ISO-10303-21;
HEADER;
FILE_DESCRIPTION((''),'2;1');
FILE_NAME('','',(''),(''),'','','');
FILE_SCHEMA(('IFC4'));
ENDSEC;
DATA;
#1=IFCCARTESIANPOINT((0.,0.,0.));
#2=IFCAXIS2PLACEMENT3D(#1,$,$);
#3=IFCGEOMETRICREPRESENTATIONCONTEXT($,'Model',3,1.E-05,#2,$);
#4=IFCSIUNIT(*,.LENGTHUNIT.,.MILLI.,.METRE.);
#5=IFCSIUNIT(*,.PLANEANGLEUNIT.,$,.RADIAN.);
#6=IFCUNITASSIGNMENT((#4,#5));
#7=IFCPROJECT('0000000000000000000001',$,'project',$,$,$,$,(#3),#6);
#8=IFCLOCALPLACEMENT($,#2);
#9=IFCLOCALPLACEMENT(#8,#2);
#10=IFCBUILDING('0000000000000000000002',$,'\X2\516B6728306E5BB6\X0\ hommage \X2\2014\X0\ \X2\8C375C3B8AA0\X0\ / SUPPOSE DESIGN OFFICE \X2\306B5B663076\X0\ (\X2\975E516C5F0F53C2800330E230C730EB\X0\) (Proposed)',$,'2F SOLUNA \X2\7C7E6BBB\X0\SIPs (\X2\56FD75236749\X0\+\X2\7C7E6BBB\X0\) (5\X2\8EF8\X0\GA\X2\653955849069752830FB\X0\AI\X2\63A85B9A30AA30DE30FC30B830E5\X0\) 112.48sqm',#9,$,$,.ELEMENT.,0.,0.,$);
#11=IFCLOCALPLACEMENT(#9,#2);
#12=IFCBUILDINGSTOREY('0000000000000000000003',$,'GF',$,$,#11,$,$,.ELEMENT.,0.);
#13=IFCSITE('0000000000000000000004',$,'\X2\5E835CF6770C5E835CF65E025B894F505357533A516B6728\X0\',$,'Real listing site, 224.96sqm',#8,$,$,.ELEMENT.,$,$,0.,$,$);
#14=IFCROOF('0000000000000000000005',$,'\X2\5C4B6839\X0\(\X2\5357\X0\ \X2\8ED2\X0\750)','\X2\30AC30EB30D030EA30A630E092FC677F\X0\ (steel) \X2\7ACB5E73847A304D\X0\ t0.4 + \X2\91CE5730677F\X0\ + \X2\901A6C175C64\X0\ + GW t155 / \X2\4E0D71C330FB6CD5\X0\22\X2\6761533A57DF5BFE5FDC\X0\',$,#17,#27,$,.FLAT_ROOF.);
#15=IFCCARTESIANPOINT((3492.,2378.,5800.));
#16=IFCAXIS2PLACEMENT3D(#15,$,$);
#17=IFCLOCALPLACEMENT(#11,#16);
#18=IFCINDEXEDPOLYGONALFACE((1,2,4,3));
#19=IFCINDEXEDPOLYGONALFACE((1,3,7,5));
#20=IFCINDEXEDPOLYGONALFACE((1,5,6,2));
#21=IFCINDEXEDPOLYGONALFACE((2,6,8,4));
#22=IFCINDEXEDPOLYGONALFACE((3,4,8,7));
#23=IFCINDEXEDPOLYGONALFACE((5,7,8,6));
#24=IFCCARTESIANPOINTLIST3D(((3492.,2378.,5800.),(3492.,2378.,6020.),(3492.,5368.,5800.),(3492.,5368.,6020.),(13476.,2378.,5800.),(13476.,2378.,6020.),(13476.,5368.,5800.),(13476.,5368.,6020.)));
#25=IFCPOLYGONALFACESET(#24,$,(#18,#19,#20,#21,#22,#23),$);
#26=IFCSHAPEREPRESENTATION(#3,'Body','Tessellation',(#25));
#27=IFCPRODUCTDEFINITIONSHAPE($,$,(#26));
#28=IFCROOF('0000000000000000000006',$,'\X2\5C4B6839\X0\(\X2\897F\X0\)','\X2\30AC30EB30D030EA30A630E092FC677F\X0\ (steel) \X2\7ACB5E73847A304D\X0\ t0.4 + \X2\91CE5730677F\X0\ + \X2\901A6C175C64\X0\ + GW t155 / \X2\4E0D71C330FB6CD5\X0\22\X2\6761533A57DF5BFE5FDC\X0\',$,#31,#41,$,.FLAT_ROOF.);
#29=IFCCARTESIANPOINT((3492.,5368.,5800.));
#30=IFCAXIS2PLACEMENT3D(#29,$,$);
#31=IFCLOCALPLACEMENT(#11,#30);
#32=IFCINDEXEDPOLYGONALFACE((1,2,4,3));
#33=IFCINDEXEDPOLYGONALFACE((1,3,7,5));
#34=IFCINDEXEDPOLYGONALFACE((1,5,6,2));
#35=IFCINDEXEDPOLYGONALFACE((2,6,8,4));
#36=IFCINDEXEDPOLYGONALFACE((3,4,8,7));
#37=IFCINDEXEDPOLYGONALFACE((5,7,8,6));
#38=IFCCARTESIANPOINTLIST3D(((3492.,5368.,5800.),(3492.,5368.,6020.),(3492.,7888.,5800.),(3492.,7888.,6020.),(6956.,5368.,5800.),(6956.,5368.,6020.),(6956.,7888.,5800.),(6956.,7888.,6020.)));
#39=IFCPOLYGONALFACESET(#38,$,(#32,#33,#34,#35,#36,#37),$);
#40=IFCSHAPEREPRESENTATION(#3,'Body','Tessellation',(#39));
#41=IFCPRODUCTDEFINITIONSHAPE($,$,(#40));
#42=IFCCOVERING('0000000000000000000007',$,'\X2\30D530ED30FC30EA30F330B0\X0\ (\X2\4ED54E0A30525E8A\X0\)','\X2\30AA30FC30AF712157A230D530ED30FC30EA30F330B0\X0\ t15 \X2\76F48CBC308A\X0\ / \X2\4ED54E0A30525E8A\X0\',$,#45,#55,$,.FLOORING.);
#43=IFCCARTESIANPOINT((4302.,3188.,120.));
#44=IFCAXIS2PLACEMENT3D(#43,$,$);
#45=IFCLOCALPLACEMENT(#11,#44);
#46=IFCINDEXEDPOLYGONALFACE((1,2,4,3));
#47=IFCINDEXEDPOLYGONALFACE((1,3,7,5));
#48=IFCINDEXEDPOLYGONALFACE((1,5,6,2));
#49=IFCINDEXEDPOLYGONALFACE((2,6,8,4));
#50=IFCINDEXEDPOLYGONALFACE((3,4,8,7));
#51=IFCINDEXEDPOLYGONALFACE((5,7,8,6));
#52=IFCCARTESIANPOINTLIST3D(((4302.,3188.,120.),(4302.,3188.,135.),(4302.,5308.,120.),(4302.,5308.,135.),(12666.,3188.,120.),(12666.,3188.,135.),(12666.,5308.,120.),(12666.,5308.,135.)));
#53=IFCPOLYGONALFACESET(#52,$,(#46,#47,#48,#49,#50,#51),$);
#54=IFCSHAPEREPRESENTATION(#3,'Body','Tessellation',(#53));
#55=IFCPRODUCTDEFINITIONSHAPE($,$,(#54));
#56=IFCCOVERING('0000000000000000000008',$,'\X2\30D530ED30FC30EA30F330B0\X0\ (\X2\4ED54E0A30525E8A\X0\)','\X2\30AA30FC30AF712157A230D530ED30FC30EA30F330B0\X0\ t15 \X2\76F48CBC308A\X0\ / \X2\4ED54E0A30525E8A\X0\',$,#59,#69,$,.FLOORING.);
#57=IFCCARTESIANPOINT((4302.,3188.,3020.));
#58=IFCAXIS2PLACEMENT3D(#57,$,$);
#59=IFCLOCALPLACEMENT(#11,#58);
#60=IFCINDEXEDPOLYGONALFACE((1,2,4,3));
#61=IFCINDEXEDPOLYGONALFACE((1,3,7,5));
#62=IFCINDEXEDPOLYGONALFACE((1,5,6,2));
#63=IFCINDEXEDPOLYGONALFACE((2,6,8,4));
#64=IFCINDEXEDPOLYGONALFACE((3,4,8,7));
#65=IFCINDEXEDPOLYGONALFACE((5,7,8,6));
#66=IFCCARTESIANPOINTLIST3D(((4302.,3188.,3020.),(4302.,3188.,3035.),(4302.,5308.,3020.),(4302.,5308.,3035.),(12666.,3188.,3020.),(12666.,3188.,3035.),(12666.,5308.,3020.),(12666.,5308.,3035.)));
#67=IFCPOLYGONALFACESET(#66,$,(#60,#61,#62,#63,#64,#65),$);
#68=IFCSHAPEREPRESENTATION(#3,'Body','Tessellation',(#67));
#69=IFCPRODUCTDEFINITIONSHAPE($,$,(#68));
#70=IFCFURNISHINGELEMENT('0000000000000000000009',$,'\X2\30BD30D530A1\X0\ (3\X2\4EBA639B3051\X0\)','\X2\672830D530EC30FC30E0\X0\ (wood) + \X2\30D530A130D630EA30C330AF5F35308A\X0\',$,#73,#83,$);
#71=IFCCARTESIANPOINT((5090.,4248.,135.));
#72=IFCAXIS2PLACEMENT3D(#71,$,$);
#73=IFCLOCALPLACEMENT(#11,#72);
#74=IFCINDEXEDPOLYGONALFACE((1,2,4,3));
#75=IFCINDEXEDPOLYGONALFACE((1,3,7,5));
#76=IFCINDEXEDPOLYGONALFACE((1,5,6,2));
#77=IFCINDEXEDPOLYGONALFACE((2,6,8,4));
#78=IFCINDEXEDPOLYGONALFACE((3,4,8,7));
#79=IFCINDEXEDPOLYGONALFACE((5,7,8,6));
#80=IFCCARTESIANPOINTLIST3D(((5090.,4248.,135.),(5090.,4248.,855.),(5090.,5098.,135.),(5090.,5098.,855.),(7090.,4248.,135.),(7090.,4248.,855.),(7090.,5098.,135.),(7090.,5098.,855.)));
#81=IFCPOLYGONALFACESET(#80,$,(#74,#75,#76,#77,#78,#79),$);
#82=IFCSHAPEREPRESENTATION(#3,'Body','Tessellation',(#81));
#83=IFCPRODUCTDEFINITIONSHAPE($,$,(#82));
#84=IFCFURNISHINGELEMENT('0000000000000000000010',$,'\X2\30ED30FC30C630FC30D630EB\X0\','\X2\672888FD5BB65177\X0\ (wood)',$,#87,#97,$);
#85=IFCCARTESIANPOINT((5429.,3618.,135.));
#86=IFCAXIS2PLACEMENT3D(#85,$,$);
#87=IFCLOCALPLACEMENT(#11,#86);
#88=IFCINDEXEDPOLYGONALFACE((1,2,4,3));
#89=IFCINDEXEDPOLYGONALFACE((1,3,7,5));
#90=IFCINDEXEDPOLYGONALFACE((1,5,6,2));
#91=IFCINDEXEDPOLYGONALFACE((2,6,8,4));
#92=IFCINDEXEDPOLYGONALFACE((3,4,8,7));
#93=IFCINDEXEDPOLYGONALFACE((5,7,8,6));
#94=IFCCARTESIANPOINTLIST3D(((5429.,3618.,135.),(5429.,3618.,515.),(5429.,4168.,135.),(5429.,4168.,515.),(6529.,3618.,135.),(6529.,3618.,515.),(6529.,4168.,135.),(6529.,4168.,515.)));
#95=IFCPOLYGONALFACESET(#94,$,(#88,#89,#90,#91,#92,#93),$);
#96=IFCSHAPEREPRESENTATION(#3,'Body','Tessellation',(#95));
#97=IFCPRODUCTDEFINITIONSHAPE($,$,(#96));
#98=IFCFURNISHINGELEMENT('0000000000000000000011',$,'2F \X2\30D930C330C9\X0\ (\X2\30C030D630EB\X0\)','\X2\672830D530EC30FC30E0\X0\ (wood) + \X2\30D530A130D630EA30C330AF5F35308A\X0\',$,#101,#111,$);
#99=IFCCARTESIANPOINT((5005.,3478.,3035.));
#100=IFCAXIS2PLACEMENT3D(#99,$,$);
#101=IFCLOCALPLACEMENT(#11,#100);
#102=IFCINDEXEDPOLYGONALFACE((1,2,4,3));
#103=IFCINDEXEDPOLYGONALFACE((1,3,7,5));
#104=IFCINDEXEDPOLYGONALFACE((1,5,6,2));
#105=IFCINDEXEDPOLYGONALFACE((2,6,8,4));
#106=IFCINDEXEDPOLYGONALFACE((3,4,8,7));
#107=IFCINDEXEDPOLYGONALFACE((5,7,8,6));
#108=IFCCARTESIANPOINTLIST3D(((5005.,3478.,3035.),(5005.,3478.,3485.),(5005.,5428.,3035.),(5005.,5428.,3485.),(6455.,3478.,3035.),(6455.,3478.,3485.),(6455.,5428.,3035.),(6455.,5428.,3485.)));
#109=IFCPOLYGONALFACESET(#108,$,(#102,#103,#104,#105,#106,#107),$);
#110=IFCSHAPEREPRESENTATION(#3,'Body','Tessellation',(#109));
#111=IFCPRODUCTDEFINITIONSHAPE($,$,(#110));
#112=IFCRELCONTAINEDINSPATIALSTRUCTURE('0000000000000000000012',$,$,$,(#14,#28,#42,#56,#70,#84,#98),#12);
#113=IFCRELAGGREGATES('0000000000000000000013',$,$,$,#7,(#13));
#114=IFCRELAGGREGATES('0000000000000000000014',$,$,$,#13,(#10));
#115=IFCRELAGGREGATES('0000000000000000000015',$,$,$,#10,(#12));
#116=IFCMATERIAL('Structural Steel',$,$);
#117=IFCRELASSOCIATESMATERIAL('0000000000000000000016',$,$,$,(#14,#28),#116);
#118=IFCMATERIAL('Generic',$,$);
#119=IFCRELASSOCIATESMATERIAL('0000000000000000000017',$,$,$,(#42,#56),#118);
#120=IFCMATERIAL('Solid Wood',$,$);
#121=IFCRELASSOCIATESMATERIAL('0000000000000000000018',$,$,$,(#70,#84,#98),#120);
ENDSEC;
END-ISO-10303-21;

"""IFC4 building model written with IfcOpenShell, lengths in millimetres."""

from ifc_helpers import new_model, si_unit, frame, frame_2d, origin, place, context, project, spatial, rectangle, extrude, material, element, save


model = new_model("IFC4")

# Units and contexts
model_context = context("Model", 3, precision=1e-05, world=origin())
ifc_project = project(units=[si_unit("LENGTHUNIT", "METRE", prefix="MILLI"), si_unit("PLANEANGLEUNIT", "RADIAN")], contexts=[model_context])

# Site, building, storey
site_placement = place(None, origin())
site = spatial("IfcSite", under=ifc_project, at=site_placement, Name="広島県広島市安佐南区八木", ObjectType="Real listing site, 224.96sqm", CompositionType="ELEMENT", RefElevation=0.0)
building_placement = place(site_placement, origin())
building = spatial("IfcBuilding", under=site, at=building_placement, Name="八木の家 hommage — 谷尻誠 / SUPPOSE DESIGN OFFICE に学ぶ (非公式参考モデル) (Proposed)", ObjectType="2F SOLUNA 籾殻SIPs (国産杉+籾殻) (5軸GA改善適用・AI推定オマージュ) 112.48sqm", CompositionType="ELEMENT", ElevationOfRefHeight=0.0, ElevationOfTerrain=0.0)
storey_placement = place(building_placement, origin())
storey = spatial("IfcBuildingStorey", under=building, at=storey_placement, Name="GF", CompositionType="ELEMENT", Elevation=0.0)

# Shared definitions
ifc_material_1 = material(Name="Solid Wood")

# Roofs
ifc_material_2 = material(Name="Structural Steel")
roof_1_placement = place(storey_placement, frame((3492.0, 2378.0, 5800.0)))
element("IfcRoof", 1, at=roof_1_placement, inside=storey, material=ifc_material_2, Name="屋根(南 軒750)", Description="ガルバリウム鋼板 (steel) 立平葺き t0.4 + 野地板 + 通気層 + GW t155 / 不燃・法22条区域対応", PredefinedType="FLAT_ROOF", context=model_context, shape_type="SweptSolid", body=[
    extrude(rectangle(XDim=9984.0, YDim=2990.0, at=frame_2d((4992.0, 1495.0))), frame((3492.0, 2378.0, 5800.0)), (0.0, 0.0, 1.0), 220.0),
])
roof_2_placement = place(storey_placement, frame((3492.0, 5368.0, 5800.0)))
element("IfcRoof", 2, at=roof_2_placement, inside=storey, material=ifc_material_2, Name="屋根(西)", Description="ガルバリウム鋼板 (steel) 立平葺き t0.4 + 野地板 + 通気層 + GW t155 / 不燃・法22条区域対応", PredefinedType="FLAT_ROOF", context=model_context, shape_type="SweptSolid", body=[
    extrude(rectangle(XDim=3464.0, YDim=2520.0, at=frame_2d((1732.0, 1260.0))), frame((3492.0, 5368.0, 5800.0)), (0.0, 0.0, 1.0), 220.0),
])

# Coverings
ifc_material_3 = material(Name="Generic")
covering_1_placement = place(storey_placement, frame((4302.0, 3188.0, 120.0)))
element("IfcCovering", 3, at=covering_1_placement, inside=storey, material=ifc_material_3, Name="フローリング (仕上げ床)", Description="オーク無垢フローリング t15 直貼り / 仕上げ床", PredefinedType="FLOORING", context=model_context, shape_type="SweptSolid", body=[
    extrude(rectangle(XDim=8364.0, YDim=2120.0, at=frame_2d((4182.0, 1060.0))), frame((4302.0, 3188.0, 120.0)), (0.0, 0.0, 1.0), 15.0),
])
covering_2_placement = place(storey_placement, frame((4302.0, 3188.0, 3020.0)))
element("IfcCovering", 4, at=covering_2_placement, inside=storey, material=ifc_material_3, Name="フローリング (仕上げ床)", Description="オーク無垢フローリング t15 直貼り / 仕上げ床", PredefinedType="FLOORING", context=model_context, shape_type="SweptSolid", body=[
    extrude(rectangle(XDim=8364.0, YDim=2120.0, at=frame_2d((4182.0, 1060.0))), frame((4302.0, 3188.0, 3020.0)), (0.0, 0.0, 1.0), 15.0),
])

# Furnishing elements
furnishing_1_placement = place(storey_placement, frame((5090.0, 4248.0, 135.0)))
element("IfcFurnishingElement", 5, at=furnishing_1_placement, inside=storey, material=ifc_material_1, Name="ソファ (3人掛け)", Description="木フレーム (wood) + ファブリック張り", context=model_context, shape_type="SweptSolid", body=[
    extrude(rectangle(XDim=2000.0, YDim=850.0, at=frame_2d((1000.0, 425.0))), frame((5090.0, 4248.0, 135.0)), (0.0, 0.0, 1.0), 720.0),
])
furnishing_2_placement = place(storey_placement, frame((5429.0, 3618.0, 135.0)))
element("IfcFurnishingElement", 6, at=furnishing_2_placement, inside=storey, material=ifc_material_1, Name="ローテーブル", Description="木製家具 (wood)", context=model_context, shape_type="SweptSolid", body=[
    extrude(rectangle(XDim=1100.0, YDim=550.0, at=frame_2d((550.0, 275.0))), frame((5429.0, 3618.0, 135.0)), (0.0, 0.0, 1.0), 380.0),
])
furnishing_3_placement = place(storey_placement, frame((5005.0, 3478.0, 3035.0)))
element("IfcFurnishingElement", 7, at=furnishing_3_placement, inside=storey, material=ifc_material_1, Name="2F ベッド (ダブル)", Description="木フレーム (wood) + ファブリック張り", context=model_context, shape_type="SweptSolid", body=[
    extrude(rectangle(XDim=1450.0, YDim=1950.0, at=frame_2d((725.0, 975.0))), frame((5005.0, 3478.0, 3035.0)), (0.0, 0.0, 1.0), 450.0),
])

save(model, "model.ifc")
